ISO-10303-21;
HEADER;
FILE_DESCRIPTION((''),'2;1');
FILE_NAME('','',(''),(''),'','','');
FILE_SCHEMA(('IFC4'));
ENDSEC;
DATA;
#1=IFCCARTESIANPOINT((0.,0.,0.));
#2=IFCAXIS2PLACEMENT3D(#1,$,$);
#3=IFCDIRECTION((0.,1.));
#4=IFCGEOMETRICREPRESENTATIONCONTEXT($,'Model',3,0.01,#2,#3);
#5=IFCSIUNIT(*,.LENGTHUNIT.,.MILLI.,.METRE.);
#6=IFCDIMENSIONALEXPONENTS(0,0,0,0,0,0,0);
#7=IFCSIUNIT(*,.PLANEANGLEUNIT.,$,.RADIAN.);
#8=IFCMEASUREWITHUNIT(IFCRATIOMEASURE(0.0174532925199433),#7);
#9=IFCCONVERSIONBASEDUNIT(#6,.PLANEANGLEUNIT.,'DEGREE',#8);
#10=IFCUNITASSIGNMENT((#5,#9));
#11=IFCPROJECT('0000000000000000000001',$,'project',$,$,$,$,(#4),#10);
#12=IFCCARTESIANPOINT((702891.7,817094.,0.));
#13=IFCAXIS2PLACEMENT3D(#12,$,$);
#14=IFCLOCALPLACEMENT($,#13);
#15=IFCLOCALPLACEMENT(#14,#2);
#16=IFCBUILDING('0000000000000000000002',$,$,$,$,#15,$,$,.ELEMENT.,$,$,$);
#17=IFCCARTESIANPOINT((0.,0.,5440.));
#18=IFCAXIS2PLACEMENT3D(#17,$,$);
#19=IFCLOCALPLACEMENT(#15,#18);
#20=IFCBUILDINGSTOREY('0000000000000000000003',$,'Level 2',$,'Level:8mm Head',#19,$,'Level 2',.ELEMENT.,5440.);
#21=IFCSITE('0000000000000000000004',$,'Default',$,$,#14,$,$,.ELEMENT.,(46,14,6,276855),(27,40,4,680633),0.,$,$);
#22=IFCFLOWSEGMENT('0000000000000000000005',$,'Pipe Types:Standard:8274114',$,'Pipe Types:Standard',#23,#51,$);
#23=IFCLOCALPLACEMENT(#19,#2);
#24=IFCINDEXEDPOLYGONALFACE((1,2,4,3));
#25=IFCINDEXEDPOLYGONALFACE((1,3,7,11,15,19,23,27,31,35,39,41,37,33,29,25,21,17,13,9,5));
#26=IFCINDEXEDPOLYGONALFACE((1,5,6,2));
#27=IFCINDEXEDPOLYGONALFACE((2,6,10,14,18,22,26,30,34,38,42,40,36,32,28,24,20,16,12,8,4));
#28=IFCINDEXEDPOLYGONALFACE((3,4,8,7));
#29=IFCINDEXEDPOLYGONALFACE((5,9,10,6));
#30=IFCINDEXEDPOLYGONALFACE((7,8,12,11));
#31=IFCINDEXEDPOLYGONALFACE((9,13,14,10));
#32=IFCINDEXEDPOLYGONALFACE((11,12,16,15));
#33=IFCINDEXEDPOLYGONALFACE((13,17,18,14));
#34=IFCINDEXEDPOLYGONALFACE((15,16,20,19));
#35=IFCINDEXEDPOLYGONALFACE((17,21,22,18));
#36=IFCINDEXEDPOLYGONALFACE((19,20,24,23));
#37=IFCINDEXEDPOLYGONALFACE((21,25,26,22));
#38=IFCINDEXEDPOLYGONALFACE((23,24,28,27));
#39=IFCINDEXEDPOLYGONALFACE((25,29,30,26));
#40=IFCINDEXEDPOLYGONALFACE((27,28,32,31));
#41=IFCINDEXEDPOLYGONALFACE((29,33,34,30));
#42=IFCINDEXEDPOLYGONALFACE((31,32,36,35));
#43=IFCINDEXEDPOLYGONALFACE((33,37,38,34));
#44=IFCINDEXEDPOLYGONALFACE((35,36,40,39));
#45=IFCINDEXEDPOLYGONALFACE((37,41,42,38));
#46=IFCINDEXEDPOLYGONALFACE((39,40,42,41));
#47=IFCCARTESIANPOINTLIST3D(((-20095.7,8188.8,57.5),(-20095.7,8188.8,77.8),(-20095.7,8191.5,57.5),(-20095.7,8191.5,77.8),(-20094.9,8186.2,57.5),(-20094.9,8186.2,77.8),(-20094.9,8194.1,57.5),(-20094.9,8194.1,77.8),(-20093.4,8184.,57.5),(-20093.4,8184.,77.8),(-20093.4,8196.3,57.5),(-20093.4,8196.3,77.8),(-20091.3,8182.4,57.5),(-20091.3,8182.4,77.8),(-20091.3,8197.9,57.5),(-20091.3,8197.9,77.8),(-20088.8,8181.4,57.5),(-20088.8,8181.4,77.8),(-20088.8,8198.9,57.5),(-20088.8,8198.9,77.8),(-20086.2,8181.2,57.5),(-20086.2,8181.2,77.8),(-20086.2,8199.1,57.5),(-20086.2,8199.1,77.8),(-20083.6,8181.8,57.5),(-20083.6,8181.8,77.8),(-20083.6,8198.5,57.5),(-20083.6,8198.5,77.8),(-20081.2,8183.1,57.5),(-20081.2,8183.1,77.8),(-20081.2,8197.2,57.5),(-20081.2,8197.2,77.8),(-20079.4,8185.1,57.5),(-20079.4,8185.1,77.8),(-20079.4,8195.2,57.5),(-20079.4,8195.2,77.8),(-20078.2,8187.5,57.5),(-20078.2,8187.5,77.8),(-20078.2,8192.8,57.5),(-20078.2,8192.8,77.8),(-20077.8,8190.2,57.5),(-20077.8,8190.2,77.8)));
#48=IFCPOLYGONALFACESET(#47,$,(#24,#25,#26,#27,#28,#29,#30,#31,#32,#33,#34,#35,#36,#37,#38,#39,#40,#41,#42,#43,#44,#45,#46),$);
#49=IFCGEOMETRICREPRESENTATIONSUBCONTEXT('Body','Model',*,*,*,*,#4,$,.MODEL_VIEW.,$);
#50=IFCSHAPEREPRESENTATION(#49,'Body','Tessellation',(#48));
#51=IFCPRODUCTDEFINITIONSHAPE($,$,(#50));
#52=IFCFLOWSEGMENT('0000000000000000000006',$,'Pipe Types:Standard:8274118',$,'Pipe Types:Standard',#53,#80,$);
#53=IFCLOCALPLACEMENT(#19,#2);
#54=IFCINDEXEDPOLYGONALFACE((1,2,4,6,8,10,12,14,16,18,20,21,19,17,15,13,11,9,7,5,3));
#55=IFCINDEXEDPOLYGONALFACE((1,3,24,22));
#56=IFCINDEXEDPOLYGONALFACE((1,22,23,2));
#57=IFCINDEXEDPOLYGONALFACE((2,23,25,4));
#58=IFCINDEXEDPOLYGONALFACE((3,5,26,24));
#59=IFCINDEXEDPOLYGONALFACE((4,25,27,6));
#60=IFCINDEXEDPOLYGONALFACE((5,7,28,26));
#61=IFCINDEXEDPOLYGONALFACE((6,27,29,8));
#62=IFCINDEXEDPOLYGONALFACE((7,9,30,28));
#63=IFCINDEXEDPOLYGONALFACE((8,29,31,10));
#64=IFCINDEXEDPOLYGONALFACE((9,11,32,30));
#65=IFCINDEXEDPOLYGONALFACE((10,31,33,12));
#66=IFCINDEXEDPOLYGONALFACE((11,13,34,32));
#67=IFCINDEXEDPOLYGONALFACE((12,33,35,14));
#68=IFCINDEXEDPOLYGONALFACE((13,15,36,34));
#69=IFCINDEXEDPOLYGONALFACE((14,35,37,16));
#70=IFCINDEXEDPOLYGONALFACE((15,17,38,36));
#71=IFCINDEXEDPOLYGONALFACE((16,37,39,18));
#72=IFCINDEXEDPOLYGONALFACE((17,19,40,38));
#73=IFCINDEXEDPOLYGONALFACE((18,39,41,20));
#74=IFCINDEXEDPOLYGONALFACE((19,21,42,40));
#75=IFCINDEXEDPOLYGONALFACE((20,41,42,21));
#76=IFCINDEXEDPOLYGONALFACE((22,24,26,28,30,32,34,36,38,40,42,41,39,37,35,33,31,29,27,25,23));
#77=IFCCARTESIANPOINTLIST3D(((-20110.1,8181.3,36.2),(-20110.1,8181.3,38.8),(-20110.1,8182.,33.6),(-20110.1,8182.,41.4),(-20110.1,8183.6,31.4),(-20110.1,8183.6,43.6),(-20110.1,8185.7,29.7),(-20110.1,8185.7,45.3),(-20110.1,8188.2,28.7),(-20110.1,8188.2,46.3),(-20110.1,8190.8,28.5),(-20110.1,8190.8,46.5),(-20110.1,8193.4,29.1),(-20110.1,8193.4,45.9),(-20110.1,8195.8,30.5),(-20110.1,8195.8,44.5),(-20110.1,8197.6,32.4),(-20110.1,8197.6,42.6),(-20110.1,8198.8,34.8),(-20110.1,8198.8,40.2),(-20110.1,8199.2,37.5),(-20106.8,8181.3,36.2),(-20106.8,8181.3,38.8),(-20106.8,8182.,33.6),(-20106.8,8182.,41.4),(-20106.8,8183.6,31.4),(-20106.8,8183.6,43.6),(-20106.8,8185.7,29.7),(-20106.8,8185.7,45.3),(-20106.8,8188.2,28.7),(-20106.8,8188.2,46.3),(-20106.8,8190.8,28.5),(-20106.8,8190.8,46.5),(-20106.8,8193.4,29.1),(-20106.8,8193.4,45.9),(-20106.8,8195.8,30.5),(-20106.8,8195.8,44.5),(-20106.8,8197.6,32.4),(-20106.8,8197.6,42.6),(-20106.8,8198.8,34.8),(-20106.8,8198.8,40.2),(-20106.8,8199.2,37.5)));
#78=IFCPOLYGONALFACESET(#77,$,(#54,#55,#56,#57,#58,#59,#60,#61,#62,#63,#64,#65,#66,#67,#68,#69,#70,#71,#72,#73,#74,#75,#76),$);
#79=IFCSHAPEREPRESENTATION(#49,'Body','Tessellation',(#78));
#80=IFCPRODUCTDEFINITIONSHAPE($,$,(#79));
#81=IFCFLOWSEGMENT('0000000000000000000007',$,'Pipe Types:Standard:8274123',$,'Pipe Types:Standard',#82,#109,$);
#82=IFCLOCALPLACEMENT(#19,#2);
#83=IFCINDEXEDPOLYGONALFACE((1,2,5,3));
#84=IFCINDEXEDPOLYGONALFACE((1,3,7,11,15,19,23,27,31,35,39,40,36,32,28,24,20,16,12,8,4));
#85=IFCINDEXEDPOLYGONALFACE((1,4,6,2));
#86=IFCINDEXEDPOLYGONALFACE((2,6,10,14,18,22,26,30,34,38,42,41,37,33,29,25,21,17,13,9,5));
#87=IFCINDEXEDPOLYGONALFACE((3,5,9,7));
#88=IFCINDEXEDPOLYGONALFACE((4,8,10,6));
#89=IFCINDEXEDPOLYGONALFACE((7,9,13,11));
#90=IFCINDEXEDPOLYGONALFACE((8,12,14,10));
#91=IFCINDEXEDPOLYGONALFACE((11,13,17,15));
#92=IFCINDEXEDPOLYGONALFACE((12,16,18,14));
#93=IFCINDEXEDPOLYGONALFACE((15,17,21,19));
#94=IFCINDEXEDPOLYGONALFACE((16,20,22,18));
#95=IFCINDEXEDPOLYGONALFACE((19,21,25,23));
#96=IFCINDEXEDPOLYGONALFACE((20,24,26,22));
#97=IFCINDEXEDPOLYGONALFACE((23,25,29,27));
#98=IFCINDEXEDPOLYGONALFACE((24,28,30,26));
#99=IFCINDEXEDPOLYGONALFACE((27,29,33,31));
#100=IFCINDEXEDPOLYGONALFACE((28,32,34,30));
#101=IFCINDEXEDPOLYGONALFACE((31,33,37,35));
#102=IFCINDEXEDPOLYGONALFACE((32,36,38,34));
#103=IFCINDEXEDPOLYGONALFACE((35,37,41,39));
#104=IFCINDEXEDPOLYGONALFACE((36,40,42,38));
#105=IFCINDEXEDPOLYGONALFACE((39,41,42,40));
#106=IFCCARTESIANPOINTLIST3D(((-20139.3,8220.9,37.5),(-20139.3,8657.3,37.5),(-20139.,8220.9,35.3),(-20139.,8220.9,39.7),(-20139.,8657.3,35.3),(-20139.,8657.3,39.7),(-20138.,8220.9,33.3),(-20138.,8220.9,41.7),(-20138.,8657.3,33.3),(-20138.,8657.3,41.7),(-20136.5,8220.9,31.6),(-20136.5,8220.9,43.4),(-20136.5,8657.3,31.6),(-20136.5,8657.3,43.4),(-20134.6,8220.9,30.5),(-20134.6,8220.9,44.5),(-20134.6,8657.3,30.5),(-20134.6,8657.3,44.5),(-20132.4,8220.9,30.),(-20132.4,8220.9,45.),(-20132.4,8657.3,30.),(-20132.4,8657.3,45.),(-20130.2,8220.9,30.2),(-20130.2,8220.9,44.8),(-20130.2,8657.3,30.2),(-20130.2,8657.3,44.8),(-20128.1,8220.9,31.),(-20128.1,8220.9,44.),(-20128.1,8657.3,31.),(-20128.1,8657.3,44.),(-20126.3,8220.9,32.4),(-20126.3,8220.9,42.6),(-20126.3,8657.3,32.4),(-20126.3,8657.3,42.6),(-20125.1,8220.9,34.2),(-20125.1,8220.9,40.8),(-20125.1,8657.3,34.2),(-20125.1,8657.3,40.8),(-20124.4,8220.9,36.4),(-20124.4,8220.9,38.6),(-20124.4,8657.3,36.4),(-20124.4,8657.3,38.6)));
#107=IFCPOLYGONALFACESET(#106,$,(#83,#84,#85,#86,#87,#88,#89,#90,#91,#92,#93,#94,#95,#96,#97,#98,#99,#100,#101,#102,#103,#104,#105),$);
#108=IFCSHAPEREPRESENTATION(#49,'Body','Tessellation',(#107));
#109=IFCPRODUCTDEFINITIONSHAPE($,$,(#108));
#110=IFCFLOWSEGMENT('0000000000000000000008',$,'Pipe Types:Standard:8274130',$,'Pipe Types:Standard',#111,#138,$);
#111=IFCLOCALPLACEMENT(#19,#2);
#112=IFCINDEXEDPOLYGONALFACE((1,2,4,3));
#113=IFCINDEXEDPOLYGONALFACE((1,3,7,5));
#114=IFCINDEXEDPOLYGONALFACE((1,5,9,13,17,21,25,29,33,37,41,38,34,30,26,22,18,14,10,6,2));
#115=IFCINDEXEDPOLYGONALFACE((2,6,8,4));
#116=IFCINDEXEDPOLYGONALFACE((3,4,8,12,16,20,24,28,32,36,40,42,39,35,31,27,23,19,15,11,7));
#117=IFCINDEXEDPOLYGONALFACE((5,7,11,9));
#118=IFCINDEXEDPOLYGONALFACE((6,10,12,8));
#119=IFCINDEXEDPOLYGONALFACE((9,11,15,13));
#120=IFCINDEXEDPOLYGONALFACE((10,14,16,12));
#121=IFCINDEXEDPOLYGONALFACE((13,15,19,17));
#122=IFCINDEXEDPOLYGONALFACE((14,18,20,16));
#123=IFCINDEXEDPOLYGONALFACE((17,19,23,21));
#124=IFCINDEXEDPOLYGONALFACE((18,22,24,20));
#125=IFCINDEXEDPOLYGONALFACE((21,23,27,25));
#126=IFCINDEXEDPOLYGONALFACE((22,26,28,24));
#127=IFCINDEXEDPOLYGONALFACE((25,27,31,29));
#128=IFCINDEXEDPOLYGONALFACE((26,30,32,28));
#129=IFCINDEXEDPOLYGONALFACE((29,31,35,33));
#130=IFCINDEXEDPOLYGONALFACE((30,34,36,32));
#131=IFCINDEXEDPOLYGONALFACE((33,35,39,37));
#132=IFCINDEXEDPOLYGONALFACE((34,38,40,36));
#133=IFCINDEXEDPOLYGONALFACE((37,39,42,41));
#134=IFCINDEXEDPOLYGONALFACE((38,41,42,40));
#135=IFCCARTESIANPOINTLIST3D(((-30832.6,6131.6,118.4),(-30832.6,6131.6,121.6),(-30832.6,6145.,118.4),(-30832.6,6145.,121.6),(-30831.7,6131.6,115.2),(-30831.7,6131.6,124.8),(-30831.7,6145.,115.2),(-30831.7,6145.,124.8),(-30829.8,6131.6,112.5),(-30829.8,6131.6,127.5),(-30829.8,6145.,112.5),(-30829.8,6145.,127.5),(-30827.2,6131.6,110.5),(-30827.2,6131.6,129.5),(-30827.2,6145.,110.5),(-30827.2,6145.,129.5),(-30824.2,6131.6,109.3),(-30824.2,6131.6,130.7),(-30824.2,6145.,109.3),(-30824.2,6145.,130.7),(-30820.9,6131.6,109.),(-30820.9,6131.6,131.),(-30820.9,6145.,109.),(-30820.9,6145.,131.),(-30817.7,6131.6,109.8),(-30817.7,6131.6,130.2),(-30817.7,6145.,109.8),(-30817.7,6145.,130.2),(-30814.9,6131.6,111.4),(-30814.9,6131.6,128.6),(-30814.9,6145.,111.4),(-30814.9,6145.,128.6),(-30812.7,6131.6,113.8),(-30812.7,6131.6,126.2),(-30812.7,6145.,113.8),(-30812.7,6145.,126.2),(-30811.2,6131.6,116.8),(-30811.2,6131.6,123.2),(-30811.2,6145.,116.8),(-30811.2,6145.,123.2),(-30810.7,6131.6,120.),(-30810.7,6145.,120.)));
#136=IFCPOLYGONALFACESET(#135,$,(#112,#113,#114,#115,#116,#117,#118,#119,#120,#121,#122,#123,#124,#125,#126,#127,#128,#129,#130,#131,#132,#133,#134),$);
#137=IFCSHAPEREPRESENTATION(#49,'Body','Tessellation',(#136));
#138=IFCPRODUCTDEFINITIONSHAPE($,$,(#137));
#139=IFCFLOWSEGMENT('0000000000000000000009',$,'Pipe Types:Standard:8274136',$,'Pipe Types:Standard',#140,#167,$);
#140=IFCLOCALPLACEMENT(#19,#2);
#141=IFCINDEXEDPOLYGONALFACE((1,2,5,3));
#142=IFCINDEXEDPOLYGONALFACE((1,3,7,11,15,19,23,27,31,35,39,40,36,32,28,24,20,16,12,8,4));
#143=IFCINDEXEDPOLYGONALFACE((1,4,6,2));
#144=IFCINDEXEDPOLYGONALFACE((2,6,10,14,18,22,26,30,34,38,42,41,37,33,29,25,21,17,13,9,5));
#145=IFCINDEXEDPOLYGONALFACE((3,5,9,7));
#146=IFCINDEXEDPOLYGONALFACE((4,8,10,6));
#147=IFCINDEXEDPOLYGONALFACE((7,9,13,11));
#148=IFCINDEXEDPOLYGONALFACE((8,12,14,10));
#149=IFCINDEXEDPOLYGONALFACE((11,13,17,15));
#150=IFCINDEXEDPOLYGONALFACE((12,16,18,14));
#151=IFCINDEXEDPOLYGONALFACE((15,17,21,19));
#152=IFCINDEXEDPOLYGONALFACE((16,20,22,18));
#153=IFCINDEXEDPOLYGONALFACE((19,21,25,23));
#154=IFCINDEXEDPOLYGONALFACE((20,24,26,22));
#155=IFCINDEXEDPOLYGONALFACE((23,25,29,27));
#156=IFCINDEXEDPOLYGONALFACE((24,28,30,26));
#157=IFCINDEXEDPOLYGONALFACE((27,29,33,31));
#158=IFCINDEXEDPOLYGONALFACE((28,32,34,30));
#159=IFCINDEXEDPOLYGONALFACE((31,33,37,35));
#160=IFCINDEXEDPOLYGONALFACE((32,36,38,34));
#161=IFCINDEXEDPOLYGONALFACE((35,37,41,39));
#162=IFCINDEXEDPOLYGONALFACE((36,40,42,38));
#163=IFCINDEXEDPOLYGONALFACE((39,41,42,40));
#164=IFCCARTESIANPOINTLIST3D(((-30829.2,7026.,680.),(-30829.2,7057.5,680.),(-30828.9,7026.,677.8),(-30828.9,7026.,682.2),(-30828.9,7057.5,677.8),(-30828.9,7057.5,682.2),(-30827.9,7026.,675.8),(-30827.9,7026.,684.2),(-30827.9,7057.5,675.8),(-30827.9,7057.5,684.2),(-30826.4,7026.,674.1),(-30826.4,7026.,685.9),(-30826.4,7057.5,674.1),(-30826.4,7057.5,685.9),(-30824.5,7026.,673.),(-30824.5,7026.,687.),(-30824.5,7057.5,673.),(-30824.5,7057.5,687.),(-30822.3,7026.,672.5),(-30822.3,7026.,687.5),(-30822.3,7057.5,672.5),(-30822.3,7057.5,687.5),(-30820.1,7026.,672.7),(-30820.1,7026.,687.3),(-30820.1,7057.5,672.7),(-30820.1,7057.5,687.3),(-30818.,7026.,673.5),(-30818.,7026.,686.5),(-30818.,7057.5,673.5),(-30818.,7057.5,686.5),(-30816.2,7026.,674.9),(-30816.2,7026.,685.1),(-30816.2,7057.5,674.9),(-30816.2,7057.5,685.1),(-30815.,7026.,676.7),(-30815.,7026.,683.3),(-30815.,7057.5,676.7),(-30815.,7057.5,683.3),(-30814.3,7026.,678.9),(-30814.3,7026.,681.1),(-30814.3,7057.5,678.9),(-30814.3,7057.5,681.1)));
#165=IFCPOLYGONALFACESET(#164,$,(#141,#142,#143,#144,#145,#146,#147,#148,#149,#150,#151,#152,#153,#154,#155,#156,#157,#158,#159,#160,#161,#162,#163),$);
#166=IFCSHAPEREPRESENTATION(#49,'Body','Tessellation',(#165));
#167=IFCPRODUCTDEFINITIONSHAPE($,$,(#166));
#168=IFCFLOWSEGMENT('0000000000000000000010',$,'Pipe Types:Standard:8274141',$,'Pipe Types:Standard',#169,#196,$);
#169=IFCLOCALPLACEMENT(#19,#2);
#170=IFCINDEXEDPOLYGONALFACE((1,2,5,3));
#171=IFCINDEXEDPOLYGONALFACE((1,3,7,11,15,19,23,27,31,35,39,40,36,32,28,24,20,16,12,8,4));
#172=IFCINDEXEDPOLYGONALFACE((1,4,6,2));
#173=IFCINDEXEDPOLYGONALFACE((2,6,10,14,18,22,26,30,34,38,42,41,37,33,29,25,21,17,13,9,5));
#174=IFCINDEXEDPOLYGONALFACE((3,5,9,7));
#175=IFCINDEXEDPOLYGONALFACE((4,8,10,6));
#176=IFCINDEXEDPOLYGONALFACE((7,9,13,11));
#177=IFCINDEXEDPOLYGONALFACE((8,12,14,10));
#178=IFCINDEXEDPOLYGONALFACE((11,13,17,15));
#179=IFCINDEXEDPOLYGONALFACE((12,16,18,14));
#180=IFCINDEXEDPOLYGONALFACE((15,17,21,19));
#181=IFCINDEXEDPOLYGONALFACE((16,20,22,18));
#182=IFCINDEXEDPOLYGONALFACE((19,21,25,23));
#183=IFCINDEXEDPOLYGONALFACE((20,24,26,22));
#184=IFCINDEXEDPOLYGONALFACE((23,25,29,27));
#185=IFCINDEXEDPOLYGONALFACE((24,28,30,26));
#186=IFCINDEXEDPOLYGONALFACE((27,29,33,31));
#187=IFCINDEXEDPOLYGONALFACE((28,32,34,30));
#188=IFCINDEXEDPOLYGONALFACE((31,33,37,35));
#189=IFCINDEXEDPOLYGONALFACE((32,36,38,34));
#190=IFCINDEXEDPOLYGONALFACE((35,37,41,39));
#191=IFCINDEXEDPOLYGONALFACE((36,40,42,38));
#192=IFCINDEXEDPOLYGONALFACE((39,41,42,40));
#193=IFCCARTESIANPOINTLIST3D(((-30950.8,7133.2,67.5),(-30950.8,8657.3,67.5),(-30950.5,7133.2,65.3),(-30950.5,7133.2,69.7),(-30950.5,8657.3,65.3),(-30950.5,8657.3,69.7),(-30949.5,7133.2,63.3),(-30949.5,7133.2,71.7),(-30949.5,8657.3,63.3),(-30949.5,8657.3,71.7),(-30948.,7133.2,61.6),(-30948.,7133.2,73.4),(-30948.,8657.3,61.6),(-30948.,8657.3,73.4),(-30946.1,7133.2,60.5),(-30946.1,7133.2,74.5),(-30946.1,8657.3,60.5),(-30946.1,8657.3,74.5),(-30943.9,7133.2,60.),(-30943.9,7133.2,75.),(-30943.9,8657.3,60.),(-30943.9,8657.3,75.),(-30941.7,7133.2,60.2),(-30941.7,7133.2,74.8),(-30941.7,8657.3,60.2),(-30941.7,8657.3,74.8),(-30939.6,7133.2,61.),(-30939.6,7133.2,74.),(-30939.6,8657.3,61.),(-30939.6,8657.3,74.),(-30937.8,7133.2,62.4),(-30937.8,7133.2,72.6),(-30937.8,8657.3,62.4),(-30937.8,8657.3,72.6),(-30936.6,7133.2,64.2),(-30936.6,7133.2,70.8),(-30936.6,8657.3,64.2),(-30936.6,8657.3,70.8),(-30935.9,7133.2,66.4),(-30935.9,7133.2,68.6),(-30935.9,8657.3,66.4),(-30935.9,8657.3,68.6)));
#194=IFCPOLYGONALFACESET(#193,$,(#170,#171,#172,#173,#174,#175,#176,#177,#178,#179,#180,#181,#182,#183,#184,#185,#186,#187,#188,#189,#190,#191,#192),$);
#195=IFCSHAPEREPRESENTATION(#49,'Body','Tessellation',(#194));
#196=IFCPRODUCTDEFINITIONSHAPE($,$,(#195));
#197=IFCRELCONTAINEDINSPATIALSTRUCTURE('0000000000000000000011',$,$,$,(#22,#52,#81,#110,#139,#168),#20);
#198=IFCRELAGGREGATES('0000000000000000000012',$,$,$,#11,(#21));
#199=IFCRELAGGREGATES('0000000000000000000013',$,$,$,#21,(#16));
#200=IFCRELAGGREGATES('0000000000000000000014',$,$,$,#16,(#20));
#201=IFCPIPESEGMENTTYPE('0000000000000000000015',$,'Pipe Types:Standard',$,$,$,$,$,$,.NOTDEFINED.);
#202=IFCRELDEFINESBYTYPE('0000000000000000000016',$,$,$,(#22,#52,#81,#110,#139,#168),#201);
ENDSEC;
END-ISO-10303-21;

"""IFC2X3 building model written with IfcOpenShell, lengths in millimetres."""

from ifc_helpers import new_model, entity, si_unit, converted_unit, direction, frame, frame_2d, origin, origin_2d_with_axis, place, context, subcontext, project, spatial, circle, extrude, type_object, element, save


model = new_model("IFC2X3")

# Units and contexts
model_context = context("Model", 3, precision=0.01, world=origin(), true_north=direction((0.0, 1.0)))
body_context = subcontext(model_context, "Body", "Model", "MODEL_VIEW")
ifc_project = project(units=[si_unit("LENGTHUNIT", "METRE", prefix="MILLI"), converted_unit("PLANEANGLEUNIT", "DEGREE", entity("IfcRatioMeasure", 0.0174532925199433), si_unit("PLANEANGLEUNIT", "RADIAN"), dimensions=[0, 0, 0, 0, 0, 0, 0])], contexts=[model_context])

# Site, building, storey
site_placement = place(None, frame((702891.7, 817094.0, 0.0)))
site = spatial("IfcSite", under=ifc_project, at=site_placement, Name="Default", CompositionType="ELEMENT", RefLatitude=(46, 14, 6, 276855), RefLongitude=(27, 40, 4, 680633), RefElevation=0.0)
building_placement = place(site_placement, origin())
building = spatial("IfcBuilding", under=site, at=building_placement, CompositionType="ELEMENT")
storey_placement = place(building_placement, frame((0.0, 0.0, 5440.0)))
storey = spatial("IfcBuildingStorey", under=building, at=storey_placement, Name="Level 2", ObjectType="Level:8mm Head", LongName="Level 2", CompositionType="ELEMENT", Elevation=5440.0)

# Flow segments
pipe_segment_type = type_object("IfcPipeSegmentType", Name="Pipe Types:Standard", PredefinedType="NOTDEFINED")
flow_segment_1_placement = place(storey_placement, origin())
element("IfcFlowSegment", 1, at=flow_segment_1_placement, inside=storey, type_object=pipe_segment_type, Name="Pipe Types:Standard:8274114", ObjectType="Pipe Types:Standard", context=body_context, shape_type="SweptSolid", body=[
    extrude(circle(Radius=9.0, at=origin_2d_with_axis()), frame((-20086.8, 8190.2, 57.5)), (0.0, 0.0, 1.0), 20.3),
])
flow_segment_2_placement = place(storey_placement, origin())
element("IfcFlowSegment", 2, at=flow_segment_2_placement, inside=storey, type_object=pipe_segment_type, Name="Pipe Types:Standard:8274118", ObjectType="Pipe Types:Standard", context=body_context, shape_type="SweptSolid", body=[
    extrude(circle(Radius=9.0, at=frame_2d((0.0, 0.0), x_axis=(1.0, 0.0))), frame((-20110.1, 8190.2, 37.5), z_axis=(1.0, 0.0, 0.0), x_axis=(0.0, 1.0, 0.0)), (0.0, 0.0, 1.0), 3.3),
])
flow_segment_3_placement = place(storey_placement, origin())
element("IfcFlowSegment", 3, at=flow_segment_3_placement, inside=storey, type_object=pipe_segment_type, Name="Pipe Types:Standard:8274123", ObjectType="Pipe Types:Standard", context=body_context, shape_type="SweptSolid", body=[
    extrude(circle(Radius=7.5, at=frame_2d((0.0, 0.0), x_axis=(1.0, 0.0))), frame((-20131.8, 8220.9, 37.5), z_axis=(0.0, 1.0, 0.0), x_axis=(-1.0, 0.0, 0.0)), (0.0, 0.0, 1.0), 436.5),
])
flow_segment_4_placement = place(storey_placement, origin())
element("IfcFlowSegment", 4, at=flow_segment_4_placement, inside=storey, type_object=pipe_segment_type, Name="Pipe Types:Standard:8274130", ObjectType="Pipe Types:Standard", context=body_context, shape_type="SweptSolid", body=[
    extrude(circle(Radius=11.0, at=origin_2d_with_axis()), frame((-30821.7, 6131.6, 120.0), z_axis=(0.0, 1.0, 0.0), x_axis=(1.0, 0.0, 0.0)), (0.0, 0.0, 1.0), 13.4),
])
flow_segment_5_placement = place(storey_placement, origin())
element("IfcFlowSegment", 5, at=flow_segment_5_placement, inside=storey, type_object=pipe_segment_type, Name="Pipe Types:Standard:8274136", ObjectType="Pipe Types:Standard", context=body_context, shape_type="SweptSolid", body=[
    extrude(circle(Radius=7.5, at=frame_2d((0.0, 0.0), x_axis=(1.0, 0.0))), frame((-30821.7, 7026.0, 680.0), z_axis=(0.0, 1.0, 0.0), x_axis=(-1.0, 0.0, 0.0)), (0.0, 0.0, 1.0), 31.5),
])
flow_segment_6_placement = place(storey_placement, origin())
element("IfcFlowSegment", 6, at=flow_segment_6_placement, inside=storey, type_object=pipe_segment_type, Name="Pipe Types:Standard:8274141", ObjectType="Pipe Types:Standard", context=body_context, shape_type="SweptSolid", body=[
    extrude(circle(Radius=7.5, at=frame_2d((0.0, 0.0), x_axis=(1.0, 0.0))), frame((-30943.3, 7133.2, 67.5), z_axis=(0.0, 1.0, 0.0), x_axis=(-1.0, 0.0, 0.0)), (0.0, 0.0, 1.0), 1524.1),
])

save(model, "model.ifc")
